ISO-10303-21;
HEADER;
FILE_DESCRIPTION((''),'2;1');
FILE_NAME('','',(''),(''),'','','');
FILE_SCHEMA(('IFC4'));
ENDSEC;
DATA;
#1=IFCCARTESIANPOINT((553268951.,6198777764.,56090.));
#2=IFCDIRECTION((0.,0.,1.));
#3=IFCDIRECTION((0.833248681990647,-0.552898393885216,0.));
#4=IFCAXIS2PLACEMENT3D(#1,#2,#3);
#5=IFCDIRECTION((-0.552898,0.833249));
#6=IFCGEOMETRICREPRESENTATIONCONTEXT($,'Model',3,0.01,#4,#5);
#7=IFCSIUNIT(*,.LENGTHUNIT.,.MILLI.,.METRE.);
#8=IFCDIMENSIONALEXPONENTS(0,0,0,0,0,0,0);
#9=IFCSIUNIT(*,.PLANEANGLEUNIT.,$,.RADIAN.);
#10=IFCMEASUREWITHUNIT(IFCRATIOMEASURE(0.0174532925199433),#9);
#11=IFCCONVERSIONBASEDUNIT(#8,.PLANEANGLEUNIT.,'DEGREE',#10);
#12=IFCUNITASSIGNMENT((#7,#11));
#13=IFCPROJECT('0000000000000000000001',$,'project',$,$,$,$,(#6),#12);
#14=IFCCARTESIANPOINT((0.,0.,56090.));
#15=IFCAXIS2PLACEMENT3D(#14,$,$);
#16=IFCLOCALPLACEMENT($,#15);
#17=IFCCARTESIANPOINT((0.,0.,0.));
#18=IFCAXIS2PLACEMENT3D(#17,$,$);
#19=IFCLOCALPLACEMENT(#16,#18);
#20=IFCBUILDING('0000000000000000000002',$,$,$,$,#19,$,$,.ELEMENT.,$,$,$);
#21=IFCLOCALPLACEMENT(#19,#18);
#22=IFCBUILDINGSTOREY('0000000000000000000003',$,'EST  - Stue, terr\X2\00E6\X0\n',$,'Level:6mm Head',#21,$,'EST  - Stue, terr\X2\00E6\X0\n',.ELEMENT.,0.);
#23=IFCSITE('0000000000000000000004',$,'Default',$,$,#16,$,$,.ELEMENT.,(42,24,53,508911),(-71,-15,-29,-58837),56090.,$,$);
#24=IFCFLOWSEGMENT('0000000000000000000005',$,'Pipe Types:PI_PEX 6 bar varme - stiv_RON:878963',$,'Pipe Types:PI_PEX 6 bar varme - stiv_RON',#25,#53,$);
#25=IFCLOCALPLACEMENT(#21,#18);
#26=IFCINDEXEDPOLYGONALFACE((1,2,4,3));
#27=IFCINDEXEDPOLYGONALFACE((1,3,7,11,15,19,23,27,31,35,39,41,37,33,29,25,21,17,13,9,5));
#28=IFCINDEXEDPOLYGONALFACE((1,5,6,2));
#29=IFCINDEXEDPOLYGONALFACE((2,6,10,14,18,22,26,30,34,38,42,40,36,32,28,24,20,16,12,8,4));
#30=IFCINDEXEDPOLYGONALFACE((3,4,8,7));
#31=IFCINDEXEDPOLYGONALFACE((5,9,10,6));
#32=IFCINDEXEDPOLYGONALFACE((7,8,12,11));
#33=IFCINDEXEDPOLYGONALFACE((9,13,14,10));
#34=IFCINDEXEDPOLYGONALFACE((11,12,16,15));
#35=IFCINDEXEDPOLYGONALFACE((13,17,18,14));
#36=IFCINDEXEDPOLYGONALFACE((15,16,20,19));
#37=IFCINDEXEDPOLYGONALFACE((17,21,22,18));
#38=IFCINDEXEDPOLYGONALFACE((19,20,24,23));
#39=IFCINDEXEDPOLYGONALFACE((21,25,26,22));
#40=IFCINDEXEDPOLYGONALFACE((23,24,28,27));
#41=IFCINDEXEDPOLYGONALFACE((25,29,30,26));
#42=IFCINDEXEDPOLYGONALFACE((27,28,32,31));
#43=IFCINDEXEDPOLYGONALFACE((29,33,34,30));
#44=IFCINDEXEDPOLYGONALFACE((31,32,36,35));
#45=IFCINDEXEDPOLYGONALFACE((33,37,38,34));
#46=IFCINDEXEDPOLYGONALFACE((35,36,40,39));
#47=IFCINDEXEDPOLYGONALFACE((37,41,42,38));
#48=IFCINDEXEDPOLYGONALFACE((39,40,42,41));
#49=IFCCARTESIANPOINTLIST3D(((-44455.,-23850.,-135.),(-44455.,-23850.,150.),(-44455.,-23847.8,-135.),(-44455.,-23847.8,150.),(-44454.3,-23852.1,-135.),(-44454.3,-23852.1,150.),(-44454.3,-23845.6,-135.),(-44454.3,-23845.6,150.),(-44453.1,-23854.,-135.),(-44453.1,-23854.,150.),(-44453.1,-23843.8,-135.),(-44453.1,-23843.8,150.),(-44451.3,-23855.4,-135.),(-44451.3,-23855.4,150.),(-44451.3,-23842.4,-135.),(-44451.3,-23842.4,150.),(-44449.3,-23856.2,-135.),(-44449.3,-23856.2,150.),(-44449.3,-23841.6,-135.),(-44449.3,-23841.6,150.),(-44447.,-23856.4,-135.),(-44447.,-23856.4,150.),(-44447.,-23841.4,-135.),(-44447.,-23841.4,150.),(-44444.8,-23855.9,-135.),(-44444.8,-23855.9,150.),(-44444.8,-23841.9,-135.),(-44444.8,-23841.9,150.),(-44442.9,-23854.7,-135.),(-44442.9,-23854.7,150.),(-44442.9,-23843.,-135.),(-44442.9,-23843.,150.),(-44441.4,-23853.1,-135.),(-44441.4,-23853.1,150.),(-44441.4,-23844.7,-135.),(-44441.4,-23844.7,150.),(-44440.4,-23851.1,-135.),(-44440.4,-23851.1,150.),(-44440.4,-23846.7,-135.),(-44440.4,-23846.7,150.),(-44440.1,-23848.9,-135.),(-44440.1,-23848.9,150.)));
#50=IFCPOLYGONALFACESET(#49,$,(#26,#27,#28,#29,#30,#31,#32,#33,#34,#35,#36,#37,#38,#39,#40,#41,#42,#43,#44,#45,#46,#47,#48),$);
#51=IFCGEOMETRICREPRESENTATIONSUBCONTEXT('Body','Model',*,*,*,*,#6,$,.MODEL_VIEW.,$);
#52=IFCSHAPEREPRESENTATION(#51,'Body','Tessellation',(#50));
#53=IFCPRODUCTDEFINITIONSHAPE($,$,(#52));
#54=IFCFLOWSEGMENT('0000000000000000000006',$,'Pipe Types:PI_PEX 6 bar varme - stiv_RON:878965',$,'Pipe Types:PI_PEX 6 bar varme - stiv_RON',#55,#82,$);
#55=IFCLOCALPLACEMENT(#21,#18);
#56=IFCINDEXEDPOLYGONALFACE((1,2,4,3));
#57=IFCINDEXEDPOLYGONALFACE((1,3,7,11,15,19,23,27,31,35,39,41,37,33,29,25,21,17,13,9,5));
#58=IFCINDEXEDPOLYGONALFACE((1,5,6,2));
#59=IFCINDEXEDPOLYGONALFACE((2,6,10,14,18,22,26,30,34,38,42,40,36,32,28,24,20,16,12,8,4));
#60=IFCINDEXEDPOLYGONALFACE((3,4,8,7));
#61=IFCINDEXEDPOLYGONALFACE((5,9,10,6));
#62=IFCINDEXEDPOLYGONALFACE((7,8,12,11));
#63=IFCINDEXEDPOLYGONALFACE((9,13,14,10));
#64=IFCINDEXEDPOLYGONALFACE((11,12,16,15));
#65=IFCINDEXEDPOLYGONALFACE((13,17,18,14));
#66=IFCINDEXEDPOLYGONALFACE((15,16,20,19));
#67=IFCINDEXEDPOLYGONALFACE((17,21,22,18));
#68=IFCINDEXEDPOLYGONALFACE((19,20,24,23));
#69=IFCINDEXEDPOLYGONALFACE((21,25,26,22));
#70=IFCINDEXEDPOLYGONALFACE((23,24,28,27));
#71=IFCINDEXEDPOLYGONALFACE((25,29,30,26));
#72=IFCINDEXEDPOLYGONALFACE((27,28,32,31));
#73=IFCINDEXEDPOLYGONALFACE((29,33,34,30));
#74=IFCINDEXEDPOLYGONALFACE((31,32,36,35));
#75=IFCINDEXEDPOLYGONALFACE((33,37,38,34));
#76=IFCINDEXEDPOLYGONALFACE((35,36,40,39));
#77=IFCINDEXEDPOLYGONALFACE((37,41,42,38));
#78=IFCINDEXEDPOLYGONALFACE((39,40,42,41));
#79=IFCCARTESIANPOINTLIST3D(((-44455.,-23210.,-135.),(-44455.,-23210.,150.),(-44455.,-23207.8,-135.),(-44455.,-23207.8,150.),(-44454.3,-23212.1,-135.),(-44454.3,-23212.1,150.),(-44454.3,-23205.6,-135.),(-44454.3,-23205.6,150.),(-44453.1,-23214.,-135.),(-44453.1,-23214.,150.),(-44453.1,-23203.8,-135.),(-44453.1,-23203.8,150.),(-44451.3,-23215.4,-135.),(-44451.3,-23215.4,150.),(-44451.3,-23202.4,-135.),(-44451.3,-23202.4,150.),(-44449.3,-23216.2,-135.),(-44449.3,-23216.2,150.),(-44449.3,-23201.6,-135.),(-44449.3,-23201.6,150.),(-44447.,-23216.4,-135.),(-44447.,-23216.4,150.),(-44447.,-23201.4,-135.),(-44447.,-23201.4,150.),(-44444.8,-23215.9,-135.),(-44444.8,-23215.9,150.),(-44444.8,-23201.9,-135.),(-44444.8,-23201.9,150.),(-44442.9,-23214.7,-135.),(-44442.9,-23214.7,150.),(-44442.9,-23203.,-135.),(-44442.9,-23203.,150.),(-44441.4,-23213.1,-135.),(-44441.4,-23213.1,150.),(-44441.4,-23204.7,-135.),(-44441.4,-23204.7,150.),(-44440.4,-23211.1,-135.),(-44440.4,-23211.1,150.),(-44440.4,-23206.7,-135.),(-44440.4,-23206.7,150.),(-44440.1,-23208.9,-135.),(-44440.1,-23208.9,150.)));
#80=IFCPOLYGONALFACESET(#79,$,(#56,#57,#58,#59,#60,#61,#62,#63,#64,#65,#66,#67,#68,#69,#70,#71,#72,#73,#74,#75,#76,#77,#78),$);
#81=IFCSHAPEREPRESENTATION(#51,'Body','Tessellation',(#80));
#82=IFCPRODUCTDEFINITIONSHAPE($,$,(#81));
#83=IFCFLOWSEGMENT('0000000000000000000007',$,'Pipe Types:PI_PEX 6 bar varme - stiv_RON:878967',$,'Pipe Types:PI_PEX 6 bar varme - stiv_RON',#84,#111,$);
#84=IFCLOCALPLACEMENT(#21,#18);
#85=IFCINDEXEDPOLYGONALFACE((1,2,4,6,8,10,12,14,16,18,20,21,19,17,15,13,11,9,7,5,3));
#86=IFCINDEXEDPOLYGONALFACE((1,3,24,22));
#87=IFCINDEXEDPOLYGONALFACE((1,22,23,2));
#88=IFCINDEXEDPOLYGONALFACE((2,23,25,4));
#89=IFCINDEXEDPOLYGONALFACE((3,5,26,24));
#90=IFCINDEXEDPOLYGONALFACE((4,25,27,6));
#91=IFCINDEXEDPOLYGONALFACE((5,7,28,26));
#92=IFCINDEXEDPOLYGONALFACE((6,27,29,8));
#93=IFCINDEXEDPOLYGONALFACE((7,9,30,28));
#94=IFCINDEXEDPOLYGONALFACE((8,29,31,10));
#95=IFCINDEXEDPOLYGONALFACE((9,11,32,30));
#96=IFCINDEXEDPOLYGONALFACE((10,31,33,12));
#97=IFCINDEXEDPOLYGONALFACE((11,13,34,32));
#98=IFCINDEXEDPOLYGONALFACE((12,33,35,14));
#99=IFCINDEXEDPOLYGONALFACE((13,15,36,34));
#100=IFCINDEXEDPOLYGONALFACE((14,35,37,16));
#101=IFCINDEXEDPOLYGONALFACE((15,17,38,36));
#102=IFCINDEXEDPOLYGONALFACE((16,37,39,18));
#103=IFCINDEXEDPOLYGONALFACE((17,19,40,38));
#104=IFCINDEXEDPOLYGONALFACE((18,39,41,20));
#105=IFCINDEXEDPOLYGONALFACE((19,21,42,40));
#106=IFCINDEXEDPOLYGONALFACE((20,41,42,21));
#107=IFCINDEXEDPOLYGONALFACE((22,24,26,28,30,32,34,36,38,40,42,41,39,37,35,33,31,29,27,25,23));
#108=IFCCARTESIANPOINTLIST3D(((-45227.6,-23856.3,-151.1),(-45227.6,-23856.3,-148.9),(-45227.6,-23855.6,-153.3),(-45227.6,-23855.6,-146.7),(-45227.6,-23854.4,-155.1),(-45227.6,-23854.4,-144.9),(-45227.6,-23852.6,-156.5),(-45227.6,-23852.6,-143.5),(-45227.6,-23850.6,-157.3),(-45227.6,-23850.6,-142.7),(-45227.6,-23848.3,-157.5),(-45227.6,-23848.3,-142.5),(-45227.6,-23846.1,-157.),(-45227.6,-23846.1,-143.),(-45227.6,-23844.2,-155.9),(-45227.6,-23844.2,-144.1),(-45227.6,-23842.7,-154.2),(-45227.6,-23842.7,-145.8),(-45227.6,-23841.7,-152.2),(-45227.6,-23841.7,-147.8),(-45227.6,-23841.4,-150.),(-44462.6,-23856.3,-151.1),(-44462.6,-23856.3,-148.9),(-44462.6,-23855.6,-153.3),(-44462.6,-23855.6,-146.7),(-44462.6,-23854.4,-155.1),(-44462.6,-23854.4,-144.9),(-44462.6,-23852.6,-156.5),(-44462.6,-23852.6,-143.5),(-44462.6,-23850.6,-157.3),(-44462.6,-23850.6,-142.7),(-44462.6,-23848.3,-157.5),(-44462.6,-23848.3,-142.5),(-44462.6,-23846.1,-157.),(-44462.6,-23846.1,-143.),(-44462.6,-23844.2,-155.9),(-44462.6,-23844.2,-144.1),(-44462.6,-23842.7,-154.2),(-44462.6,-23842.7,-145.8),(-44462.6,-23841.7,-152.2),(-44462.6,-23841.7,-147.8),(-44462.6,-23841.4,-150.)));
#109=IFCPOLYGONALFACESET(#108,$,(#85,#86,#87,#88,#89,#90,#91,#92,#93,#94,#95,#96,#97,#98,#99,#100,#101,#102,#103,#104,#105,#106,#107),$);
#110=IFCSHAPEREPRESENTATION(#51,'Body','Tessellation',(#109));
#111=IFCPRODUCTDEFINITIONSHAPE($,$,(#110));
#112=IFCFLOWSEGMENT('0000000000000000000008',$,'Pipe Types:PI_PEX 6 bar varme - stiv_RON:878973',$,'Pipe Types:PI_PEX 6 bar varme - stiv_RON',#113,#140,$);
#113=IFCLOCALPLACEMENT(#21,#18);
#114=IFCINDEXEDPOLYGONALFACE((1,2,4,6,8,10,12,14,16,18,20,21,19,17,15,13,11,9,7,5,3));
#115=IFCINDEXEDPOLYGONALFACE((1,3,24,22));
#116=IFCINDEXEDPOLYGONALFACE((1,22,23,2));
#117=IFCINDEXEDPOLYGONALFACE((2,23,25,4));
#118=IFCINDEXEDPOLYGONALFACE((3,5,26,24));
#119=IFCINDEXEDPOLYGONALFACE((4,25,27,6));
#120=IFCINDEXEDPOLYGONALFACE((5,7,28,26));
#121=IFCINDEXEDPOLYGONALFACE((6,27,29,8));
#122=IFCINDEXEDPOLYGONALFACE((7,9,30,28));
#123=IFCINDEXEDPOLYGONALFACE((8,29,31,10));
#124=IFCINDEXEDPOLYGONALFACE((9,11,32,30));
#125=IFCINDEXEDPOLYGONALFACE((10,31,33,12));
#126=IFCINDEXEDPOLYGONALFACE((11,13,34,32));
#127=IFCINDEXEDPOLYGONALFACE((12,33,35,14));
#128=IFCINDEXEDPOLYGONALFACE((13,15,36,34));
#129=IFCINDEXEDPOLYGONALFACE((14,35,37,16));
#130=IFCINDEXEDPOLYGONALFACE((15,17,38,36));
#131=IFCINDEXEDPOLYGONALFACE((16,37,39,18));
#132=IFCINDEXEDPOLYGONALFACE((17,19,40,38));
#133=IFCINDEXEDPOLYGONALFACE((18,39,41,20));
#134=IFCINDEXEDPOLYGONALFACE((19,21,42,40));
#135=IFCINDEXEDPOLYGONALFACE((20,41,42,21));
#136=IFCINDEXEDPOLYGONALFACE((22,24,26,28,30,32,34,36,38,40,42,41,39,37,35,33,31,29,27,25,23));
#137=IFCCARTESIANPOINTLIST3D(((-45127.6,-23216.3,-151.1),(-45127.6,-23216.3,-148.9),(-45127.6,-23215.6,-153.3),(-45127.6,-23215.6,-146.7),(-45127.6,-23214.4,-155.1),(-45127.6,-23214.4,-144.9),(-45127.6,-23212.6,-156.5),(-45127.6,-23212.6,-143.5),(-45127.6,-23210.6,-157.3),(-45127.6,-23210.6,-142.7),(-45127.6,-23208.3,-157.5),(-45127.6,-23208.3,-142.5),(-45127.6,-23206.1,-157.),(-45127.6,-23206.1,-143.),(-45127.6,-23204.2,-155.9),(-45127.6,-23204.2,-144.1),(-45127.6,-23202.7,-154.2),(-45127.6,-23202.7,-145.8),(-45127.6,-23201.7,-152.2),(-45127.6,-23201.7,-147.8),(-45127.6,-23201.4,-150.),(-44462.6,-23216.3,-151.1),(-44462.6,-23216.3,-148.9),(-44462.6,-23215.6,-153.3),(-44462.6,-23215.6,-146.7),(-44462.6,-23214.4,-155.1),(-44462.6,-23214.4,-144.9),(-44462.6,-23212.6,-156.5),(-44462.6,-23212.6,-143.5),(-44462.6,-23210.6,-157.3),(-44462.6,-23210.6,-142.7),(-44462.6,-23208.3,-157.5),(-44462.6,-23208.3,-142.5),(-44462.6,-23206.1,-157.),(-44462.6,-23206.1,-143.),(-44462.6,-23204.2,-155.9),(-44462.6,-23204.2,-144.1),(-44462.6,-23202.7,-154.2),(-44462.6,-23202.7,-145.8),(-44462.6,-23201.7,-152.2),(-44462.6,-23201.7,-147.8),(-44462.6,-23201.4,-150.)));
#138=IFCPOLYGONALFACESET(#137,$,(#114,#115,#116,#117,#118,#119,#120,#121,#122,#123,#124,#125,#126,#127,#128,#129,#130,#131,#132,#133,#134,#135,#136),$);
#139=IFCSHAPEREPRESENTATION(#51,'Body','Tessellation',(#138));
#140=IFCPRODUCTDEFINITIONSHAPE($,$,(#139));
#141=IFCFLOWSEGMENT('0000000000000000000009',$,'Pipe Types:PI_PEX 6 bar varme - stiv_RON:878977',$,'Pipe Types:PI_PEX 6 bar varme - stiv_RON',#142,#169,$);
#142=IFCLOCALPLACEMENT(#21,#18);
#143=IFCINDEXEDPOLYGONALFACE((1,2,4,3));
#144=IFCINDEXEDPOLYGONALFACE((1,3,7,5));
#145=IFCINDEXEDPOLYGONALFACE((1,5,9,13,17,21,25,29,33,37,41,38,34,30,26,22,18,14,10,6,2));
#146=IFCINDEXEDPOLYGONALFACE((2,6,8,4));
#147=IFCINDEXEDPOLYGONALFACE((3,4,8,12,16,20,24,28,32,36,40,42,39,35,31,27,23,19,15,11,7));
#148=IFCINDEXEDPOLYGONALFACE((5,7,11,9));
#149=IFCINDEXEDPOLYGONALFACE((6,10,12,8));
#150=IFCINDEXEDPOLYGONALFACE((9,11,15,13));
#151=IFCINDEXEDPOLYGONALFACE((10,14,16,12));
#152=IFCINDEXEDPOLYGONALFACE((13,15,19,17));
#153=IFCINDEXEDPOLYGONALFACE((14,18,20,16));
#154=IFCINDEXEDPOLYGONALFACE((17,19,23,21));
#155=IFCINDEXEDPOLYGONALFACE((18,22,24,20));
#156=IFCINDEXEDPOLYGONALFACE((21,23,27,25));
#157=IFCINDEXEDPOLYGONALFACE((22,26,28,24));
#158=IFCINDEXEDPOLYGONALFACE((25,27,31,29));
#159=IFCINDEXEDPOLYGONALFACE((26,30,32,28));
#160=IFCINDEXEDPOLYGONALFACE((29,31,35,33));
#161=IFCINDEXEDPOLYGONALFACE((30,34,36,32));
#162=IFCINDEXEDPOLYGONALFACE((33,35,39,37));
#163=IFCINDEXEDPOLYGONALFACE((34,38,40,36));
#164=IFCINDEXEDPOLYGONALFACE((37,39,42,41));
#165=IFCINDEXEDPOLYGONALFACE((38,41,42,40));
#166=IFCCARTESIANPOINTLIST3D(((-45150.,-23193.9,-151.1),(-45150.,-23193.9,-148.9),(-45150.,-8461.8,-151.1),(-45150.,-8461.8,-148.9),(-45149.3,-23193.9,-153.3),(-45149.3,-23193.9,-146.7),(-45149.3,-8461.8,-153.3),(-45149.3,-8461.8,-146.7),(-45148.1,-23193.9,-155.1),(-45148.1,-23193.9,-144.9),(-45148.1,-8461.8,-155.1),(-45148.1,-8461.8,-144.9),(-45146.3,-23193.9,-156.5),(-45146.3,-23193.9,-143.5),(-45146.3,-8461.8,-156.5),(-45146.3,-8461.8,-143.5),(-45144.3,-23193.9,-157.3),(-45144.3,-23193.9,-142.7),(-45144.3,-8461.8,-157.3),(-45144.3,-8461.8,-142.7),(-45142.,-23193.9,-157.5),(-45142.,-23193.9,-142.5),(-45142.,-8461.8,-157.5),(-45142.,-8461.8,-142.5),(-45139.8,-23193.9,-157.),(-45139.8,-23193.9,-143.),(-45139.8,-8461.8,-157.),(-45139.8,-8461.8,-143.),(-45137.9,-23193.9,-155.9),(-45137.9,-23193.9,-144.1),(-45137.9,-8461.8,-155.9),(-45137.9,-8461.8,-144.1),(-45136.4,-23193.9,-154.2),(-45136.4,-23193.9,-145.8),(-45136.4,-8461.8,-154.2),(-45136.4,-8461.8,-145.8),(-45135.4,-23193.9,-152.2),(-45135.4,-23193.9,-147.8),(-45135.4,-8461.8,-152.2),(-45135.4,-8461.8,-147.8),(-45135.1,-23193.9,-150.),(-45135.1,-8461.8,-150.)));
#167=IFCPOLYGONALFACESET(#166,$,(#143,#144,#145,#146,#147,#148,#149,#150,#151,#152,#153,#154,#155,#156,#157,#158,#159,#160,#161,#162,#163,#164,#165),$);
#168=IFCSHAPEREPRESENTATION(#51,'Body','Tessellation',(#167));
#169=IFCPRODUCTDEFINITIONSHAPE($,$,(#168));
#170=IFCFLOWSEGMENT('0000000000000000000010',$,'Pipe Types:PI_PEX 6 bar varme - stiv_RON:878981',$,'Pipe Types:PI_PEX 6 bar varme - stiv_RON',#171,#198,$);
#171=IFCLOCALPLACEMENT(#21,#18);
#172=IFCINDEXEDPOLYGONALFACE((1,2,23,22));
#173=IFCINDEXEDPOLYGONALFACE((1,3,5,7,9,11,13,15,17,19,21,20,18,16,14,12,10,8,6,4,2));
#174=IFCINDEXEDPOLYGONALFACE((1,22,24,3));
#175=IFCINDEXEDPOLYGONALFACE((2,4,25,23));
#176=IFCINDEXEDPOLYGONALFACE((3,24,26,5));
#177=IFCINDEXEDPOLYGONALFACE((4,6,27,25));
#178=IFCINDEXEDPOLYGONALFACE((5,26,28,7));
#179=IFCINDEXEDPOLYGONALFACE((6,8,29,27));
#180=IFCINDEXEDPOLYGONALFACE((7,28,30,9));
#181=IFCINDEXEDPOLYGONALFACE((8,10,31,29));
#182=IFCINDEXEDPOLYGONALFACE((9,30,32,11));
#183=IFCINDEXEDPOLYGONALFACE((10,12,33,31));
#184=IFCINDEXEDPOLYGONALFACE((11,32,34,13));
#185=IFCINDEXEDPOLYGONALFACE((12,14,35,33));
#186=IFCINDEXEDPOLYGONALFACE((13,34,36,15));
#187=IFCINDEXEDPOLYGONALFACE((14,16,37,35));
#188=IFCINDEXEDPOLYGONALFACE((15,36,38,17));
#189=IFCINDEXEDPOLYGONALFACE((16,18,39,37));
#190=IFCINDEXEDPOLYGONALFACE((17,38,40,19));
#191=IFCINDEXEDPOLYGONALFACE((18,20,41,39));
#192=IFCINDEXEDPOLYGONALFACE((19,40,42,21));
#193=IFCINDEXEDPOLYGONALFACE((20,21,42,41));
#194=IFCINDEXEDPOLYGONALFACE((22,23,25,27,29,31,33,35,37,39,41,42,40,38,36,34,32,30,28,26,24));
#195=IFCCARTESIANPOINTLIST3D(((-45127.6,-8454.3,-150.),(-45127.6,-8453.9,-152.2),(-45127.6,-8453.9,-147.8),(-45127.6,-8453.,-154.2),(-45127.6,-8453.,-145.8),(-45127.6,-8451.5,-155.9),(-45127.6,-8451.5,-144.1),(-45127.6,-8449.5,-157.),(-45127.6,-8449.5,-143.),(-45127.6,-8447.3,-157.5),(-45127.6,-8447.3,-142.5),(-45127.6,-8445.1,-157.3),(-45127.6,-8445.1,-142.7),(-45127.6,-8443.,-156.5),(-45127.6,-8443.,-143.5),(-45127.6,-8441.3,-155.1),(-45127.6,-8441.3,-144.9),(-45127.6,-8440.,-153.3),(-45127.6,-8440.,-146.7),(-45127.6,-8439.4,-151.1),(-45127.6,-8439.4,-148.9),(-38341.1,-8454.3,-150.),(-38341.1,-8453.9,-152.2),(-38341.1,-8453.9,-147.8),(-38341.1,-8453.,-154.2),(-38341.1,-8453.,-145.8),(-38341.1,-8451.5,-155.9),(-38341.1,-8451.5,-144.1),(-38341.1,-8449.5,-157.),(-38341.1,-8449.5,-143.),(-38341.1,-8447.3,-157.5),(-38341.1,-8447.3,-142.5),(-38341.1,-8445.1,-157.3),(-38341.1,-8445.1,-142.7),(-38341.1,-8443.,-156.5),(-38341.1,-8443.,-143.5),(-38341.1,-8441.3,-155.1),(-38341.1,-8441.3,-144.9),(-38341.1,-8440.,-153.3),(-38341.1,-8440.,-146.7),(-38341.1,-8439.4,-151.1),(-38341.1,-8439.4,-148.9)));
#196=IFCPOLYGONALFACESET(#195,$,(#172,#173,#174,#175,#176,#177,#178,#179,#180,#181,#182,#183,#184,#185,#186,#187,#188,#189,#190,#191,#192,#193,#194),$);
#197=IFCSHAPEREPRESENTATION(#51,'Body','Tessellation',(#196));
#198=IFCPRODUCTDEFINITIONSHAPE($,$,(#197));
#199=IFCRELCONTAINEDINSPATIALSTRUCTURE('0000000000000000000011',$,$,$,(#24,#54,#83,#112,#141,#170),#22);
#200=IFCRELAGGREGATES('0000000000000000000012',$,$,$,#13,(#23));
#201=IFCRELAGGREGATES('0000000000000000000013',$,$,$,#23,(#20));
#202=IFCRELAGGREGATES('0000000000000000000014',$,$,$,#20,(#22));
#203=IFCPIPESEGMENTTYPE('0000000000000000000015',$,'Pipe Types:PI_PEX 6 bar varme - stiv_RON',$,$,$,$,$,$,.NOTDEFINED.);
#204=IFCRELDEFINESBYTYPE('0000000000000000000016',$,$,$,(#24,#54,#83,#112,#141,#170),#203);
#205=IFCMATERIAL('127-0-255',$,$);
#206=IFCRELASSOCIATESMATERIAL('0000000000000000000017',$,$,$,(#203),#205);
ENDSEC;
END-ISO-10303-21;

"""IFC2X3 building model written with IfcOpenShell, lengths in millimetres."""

from ifc_helpers import new_model, entity, si_unit, converted_unit, direction, frame, frame_2d, origin, origin_2d_with_axis, place, context, subcontext, project, spatial, circle, extrude, material, type_object, element, save


model = new_model("IFC2X3")

# Units and contexts
model_context = context("Model", 3, precision=0.01, world=frame((553268951.0, 6198777764.0, 56090.0), z_axis=(0.0, 0.0, 1.0), x_axis=(0.833248681990647, -0.552898393885216, 0.0)), true_north=direction((-0.552898, 0.833249)))
body_context = subcontext(model_context, "Body", "Model", "MODEL_VIEW")
ifc_project = project(units=[si_unit("LENGTHUNIT", "METRE", prefix="MILLI"), converted_unit("PLANEANGLEUNIT", "DEGREE", entity("IfcRatioMeasure", 0.0174532925199433), si_unit("PLANEANGLEUNIT", "RADIAN"), dimensions=[0, 0, 0, 0, 0, 0, 0])], contexts=[model_context])

# Site, building, storey
site_placement = place(None, frame((0.0, 0.0, 56090.0)))
site = spatial("IfcSite", under=ifc_project, at=site_placement, Name="Default", CompositionType="ELEMENT", RefLatitude=(42, 24, 53, 508911), RefLongitude=(-71, -15, -29, -58837), RefElevation=56090.0)
building_placement = place(site_placement, origin())
building = spatial("IfcBuilding", under=site, at=building_placement, CompositionType="ELEMENT")
storey_placement = place(building_placement, frame((0.0, 0.0, 0.0)))
storey = spatial("IfcBuildingStorey", under=building, at=storey_placement, Name="EST  - Stue, terræn", ObjectType="Level:6mm Head", LongName="EST  - Stue, terræn", CompositionType="ELEMENT", Elevation=0.0)

# Flow segments
ifc_material_1 = material(Name="127-0-255")
pipe_segment_type_1 = type_object("IfcPipeSegmentType", Name="Pipe Types:PI_PEX 6 bar varme - stiv_RON", PredefinedType="NOTDEFINED", material=ifc_material_1)
flow_segment_1_placement = place(storey_placement, origin())
element("IfcFlowSegment", 1, at=flow_segment_1_placement, inside=storey, type_object=pipe_segment_type_1, Name="Pipe Types:PI_PEX 6 bar varme - stiv_RON:878963", ObjectType="Pipe Types:PI_PEX 6 bar varme - stiv_RON", context=body_context, shape_type="SweptSolid", body=[
    extrude(circle(Radius=7.5, at=origin_2d_with_axis()), frame((-44447.6, -23848.9, -135.0)), (0.0, 0.0, 1.0), 285.0),
])
flow_segment_2_placement = place(storey_placement, origin())
element("IfcFlowSegment", 2, at=flow_segment_2_placement, inside=storey, type_object=pipe_segment_type_1, Name="Pipe Types:PI_PEX 6 bar varme - stiv_RON:878965", ObjectType="Pipe Types:PI_PEX 6 bar varme - stiv_RON", context=body_context, shape_type="SweptSolid", body=[
    extrude(circle(Radius=7.5, at=origin_2d_with_axis()), frame((-44447.6, -23208.9, -135.0)), (0.0, 0.0, 1.0), 285.0),
])
flow_segment_3_placement = place(storey_placement, origin())
element("IfcFlowSegment", 3, at=flow_segment_3_placement, inside=storey, type_object=pipe_segment_type_1, Name="Pipe Types:PI_PEX 6 bar varme - stiv_RON:878967", ObjectType="Pipe Types:PI_PEX 6 bar varme - stiv_RON", context=body_context, shape_type="SweptSolid", body=[
    extrude(circle(Radius=7.5, at=frame_2d((0.0, 0.0), x_axis=(1.0, 0.0))), frame((-45227.6, -23848.9, -150.0), z_axis=(1.0, 0.0, 0.0), x_axis=(0.0, 1.0, 0.0)), (0.0, 0.0, 1.0), 765.0),
])
flow_segment_4_placement = place(storey_placement, origin())
element("IfcFlowSegment", 4, at=flow_segment_4_placement, inside=storey, type_object=pipe_segment_type_1, Name="Pipe Types:PI_PEX 6 bar varme - stiv_RON:878973", ObjectType="Pipe Types:PI_PEX 6 bar varme - stiv_RON", context=body_context, shape_type="SweptSolid", body=[
    extrude(circle(Radius=7.5, at=frame_2d((0.0, 0.0), x_axis=(1.0, 0.0))), frame((-45127.6, -23208.9, -150.0), z_axis=(1.0, 0.0, 0.0), x_axis=(0.0, 1.0, 0.0)), (0.0, 0.0, 1.0), 665.0),
])
flow_segment_5_placement = place(storey_placement, origin())
element("IfcFlowSegment", 5, at=flow_segment_5_placement, inside=storey, type_object=pipe_segment_type_1, Name="Pipe Types:PI_PEX 6 bar varme - stiv_RON:878977", ObjectType="Pipe Types:PI_PEX 6 bar varme - stiv_RON", context=body_context, shape_type="SweptSolid", body=[
    extrude(circle(Radius=7.5, at=origin_2d_with_axis()), frame((-45142.6, -23193.9, -150.0), z_axis=(0.0, 1.0, 0.0), x_axis=(1.0, 0.0, 0.0)), (0.0, 0.0, 1.0), 14732.1),
])
flow_segment_6_placement = place(storey_placement, origin())
element("IfcFlowSegment", 6, at=flow_segment_6_placement, inside=storey, type_object=pipe_segment_type_1, Name="Pipe Types:PI_PEX 6 bar varme - stiv_RON:878981", ObjectType="Pipe Types:PI_PEX 6 bar varme - stiv_RON", context=body_context, shape_type="SweptSolid", body=[
    extrude(circle(Radius=7.5, at=origin_2d_with_axis()), frame((-45127.6, -8446.8, -150.0), z_axis=(1.0, 0.0, 0.0), x_axis=(0.0, -1.0, 0.0)), (0.0, 0.0, 1.0), 6786.5),
])

save(model, "model.ifc")
